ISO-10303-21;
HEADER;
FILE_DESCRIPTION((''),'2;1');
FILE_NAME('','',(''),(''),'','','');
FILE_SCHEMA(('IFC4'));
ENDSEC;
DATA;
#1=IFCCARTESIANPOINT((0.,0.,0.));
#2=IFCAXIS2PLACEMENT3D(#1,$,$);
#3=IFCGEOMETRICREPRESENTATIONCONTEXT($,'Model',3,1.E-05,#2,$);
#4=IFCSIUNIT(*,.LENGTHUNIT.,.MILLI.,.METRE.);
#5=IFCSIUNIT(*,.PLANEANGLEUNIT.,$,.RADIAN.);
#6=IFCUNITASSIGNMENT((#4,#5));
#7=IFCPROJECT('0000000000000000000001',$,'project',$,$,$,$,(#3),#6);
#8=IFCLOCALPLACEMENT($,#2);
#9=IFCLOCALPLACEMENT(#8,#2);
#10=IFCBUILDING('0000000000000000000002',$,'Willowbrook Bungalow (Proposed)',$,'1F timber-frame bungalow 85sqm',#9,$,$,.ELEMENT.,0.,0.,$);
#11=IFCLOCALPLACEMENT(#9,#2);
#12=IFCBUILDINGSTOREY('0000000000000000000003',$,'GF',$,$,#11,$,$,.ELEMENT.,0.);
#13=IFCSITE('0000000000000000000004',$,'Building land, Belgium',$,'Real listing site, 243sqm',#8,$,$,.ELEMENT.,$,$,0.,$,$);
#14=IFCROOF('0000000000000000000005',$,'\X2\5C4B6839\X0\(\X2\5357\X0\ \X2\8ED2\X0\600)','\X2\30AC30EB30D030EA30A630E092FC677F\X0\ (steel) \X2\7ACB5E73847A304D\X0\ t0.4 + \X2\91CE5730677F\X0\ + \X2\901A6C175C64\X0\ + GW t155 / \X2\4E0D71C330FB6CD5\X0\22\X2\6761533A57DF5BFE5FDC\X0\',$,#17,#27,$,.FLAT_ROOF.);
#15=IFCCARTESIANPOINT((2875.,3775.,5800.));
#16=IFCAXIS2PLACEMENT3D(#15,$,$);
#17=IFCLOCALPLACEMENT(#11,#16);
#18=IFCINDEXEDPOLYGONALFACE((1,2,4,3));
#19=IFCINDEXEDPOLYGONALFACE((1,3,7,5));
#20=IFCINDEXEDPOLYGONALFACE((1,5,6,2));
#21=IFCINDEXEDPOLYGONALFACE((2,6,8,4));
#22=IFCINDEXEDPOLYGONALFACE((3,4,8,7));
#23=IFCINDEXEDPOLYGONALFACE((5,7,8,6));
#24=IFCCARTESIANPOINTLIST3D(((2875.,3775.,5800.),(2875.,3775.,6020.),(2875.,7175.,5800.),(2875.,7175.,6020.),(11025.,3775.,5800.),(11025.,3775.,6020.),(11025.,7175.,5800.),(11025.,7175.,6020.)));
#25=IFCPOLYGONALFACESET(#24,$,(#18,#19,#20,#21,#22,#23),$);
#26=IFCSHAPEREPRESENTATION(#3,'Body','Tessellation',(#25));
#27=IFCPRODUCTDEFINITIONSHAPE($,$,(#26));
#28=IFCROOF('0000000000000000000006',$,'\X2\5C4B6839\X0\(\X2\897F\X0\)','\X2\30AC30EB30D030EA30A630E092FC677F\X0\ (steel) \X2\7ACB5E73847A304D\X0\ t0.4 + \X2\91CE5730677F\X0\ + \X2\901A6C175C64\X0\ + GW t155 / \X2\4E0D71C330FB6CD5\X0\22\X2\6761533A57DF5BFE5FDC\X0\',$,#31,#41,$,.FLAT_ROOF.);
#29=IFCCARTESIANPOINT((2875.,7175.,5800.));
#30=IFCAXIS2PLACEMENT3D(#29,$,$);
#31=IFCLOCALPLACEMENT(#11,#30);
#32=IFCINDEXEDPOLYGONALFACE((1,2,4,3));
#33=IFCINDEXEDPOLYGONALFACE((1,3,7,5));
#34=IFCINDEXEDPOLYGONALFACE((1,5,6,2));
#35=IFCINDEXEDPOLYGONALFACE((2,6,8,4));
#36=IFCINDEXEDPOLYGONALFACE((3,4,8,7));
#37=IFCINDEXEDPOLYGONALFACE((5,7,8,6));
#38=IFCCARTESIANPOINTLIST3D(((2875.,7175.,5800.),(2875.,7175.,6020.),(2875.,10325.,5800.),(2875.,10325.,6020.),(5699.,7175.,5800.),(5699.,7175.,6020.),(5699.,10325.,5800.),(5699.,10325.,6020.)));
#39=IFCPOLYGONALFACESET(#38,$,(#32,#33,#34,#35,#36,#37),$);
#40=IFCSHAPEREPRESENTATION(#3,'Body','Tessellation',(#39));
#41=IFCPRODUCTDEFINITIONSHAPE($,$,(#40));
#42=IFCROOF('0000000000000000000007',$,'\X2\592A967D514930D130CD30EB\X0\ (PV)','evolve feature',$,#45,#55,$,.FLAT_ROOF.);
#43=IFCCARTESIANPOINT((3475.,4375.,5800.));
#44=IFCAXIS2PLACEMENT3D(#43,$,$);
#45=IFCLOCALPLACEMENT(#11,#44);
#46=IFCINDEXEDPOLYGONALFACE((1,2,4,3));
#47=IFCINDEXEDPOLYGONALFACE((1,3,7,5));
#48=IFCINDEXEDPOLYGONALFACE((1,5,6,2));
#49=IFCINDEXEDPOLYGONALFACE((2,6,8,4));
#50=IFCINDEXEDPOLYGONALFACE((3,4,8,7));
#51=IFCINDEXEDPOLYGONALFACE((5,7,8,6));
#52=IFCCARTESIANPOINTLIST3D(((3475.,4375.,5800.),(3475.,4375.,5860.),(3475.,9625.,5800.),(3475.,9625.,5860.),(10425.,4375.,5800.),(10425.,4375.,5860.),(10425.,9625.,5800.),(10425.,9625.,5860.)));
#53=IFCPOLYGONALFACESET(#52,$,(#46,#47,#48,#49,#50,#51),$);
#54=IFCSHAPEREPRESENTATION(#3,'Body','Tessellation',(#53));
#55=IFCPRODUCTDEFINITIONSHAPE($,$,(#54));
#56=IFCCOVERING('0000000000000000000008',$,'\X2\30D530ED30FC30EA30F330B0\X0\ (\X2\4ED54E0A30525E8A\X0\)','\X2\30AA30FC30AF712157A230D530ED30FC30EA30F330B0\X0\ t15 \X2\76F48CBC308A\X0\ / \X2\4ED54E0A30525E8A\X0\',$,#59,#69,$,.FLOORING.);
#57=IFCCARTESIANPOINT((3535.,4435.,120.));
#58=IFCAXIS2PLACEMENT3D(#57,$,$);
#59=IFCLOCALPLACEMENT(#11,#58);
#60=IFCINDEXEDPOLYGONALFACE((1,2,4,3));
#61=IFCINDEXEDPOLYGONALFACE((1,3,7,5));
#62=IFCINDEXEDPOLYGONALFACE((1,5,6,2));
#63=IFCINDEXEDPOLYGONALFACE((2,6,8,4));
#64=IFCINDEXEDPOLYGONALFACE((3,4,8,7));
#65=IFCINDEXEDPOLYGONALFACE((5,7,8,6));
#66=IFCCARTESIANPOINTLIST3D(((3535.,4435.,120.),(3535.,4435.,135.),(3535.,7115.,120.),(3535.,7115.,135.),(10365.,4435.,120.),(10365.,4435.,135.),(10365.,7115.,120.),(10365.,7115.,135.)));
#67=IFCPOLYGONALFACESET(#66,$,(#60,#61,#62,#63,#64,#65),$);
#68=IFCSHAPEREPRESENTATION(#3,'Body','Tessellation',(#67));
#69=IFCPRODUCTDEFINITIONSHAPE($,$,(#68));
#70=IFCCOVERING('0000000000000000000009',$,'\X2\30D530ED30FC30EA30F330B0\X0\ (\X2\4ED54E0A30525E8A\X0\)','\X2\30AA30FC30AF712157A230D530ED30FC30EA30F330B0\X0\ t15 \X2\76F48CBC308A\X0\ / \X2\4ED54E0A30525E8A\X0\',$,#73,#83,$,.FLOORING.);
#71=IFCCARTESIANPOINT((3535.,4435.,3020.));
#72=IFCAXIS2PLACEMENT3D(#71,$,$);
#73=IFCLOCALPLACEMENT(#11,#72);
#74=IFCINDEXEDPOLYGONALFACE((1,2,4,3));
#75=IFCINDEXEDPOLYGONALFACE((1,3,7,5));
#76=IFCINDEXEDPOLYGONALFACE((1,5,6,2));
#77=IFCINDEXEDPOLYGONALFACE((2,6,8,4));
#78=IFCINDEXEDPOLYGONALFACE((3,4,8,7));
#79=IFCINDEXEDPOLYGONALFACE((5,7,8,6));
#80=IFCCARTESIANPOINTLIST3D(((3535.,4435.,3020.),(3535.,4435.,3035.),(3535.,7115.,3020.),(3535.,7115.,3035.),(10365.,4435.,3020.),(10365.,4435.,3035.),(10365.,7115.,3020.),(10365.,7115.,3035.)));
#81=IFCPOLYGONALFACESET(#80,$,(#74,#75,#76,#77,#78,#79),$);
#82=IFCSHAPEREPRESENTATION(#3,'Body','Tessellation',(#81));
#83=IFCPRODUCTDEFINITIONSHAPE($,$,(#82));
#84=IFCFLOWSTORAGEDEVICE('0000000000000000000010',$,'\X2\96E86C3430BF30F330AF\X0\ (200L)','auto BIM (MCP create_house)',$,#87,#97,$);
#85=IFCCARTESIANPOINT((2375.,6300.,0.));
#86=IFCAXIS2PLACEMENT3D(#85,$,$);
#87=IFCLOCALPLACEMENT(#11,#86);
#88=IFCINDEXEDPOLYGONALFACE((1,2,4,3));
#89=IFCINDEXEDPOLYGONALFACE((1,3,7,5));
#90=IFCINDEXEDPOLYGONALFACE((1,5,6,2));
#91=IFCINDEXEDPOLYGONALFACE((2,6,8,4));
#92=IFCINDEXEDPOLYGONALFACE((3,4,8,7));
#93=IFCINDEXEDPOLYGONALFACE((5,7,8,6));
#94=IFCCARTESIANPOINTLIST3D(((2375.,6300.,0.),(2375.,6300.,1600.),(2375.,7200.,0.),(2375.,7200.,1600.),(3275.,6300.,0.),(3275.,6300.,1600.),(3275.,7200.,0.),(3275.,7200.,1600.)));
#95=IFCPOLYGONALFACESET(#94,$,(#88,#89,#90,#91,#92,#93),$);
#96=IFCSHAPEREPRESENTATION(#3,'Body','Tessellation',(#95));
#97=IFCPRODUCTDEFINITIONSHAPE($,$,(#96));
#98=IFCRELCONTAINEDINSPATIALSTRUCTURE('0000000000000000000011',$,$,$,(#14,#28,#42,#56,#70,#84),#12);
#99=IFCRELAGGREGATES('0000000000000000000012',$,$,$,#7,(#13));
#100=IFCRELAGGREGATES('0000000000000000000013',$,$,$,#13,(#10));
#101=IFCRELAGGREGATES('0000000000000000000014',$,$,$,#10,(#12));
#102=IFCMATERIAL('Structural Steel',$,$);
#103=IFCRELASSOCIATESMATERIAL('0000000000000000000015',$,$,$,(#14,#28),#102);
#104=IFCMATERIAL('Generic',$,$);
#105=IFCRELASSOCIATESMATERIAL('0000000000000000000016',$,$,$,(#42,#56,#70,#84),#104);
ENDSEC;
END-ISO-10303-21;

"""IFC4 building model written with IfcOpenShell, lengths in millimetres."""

from ifc_helpers import new_model, si_unit, frame, frame_2d, origin, place, context, project, spatial, rectangle, extrude, material, element, save


model = new_model("IFC4")

# Units and contexts
model_context = context("Model", 3, precision=1e-05, world=origin())
ifc_project = project(units=[si_unit("LENGTHUNIT", "METRE", prefix="MILLI"), si_unit("PLANEANGLEUNIT", "RADIAN")], contexts=[model_context])

# Site, building, storey
site_placement = place(None, origin())
site = spatial("IfcSite", under=ifc_project, at=site_placement, Name="Building land, Belgium", ObjectType="Real listing site, 243sqm", CompositionType="ELEMENT", RefElevation=0.0)
building_placement = place(site_placement, origin())
building = spatial("IfcBuilding", under=site, at=building_placement, Name="Willowbrook Bungalow (Proposed)", ObjectType="1F timber-frame bungalow 85sqm", CompositionType="ELEMENT", ElevationOfRefHeight=0.0, ElevationOfTerrain=0.0)
storey_placement = place(building_placement, origin())
storey = spatial("IfcBuildingStorey", under=building, at=storey_placement, Name="GF", CompositionType="ELEMENT", Elevation=0.0)

# Shared definitions
ifc_material_1 = material(Name="Generic")

# Roofs
ifc_material_2 = material(Name="Structural Steel")
roof_1_placement = place(storey_placement, frame((2875.0, 3775.0, 5800.0)))
element("IfcRoof", 1, at=roof_1_placement, inside=storey, material=ifc_material_2, Name="屋根(南 軒600)", Description="ガルバリウム鋼板 (steel) 立平葺き t0.4 + 野地板 + 通気層 + GW t155 / 不燃・法22条区域対応", PredefinedType="FLAT_ROOF", context=model_context, shape_type="SweptSolid", body=[
    extrude(rectangle(XDim=8150.0, YDim=3400.0, at=frame_2d((4075.0, 1700.0))), frame((2875.0, 3775.0, 5800.0)), (0.0, 0.0, 1.0), 220.0),
])
roof_2_placement = place(storey_placement, frame((2875.0, 7175.0, 5800.0)))
element("IfcRoof", 2, at=roof_2_placement, inside=storey, material=ifc_material_2, Name="屋根(西)", Description="ガルバリウム鋼板 (steel) 立平葺き t0.4 + 野地板 + 通気層 + GW t155 / 不燃・法22条区域対応", PredefinedType="FLAT_ROOF", context=model_context, shape_type="SweptSolid", body=[
    extrude(rectangle(XDim=2824.0, YDim=3150.0, at=frame_2d((1412.0, 1575.0))), frame((2875.0, 7175.0, 5800.0)), (0.0, 0.0, 1.0), 220.0),
])
roof_3_placement = place(storey_placement, frame((3475.0, 4375.0, 5800.0)))
element("IfcRoof", 3, at=roof_3_placement, inside=storey, material=ifc_material_1, Name="太陽光パネル (PV)", Description="evolve feature", PredefinedType="FLAT_ROOF", context=model_context, shape_type="SweptSolid", body=[
    extrude(rectangle(XDim=6950.0, YDim=5250.0, at=frame_2d((3475.0, 2625.0))), frame((3475.0, 4375.0, 5800.0)), (0.0, 0.0, 1.0), 60.0),
])

# Coverings
covering_1_placement = place(storey_placement, frame((3535.0, 4435.0, 120.0)))
element("IfcCovering", 4, at=covering_1_placement, inside=storey, material=ifc_material_1, Name="フローリング (仕上げ床)", Description="オーク無垢フローリング t15 直貼り / 仕上げ床", PredefinedType="FLOORING", context=model_context, shape_type="SweptSolid", body=[
    extrude(rectangle(XDim=6830.0, YDim=2680.0, at=frame_2d((3415.0, 1340.0))), frame((3535.0, 4435.0, 120.0)), (0.0, 0.0, 1.0), 15.0),
])
covering_2_placement = place(storey_placement, frame((3535.0, 4435.0, 3020.0)))
element("IfcCovering", 5, at=covering_2_placement, inside=storey, material=ifc_material_1, Name="フローリング (仕上げ床)", Description="オーク無垢フローリング t15 直貼り / 仕上げ床", PredefinedType="FLOORING", context=model_context, shape_type="SweptSolid", body=[
    extrude(rectangle(XDim=6830.0, YDim=2680.0, at=frame_2d((3415.0, 1340.0))), frame((3535.0, 4435.0, 3020.0)), (0.0, 0.0, 1.0), 15.0),
])

# Flow storage device
flow_storage_device_placement = place(storey_placement, frame((2375.0, 6300.0, 0.0)))
element("IfcFlowStorageDevice", 6, at=flow_storage_device_placement, inside=storey, material=ifc_material_1, Name="雨水タンク (200L)", Description="auto BIM (MCP create_house)", context=model_context, shape_type="SweptSolid", body=[
    extrude(rectangle(XDim=900.0, YDim=900.0, at=frame_2d((450.0, 450.0))), frame((2375.0, 6300.0, 0.0)), (0.0, 0.0, 1.0), 1600.0),
])

save(model, "model.ifc")
